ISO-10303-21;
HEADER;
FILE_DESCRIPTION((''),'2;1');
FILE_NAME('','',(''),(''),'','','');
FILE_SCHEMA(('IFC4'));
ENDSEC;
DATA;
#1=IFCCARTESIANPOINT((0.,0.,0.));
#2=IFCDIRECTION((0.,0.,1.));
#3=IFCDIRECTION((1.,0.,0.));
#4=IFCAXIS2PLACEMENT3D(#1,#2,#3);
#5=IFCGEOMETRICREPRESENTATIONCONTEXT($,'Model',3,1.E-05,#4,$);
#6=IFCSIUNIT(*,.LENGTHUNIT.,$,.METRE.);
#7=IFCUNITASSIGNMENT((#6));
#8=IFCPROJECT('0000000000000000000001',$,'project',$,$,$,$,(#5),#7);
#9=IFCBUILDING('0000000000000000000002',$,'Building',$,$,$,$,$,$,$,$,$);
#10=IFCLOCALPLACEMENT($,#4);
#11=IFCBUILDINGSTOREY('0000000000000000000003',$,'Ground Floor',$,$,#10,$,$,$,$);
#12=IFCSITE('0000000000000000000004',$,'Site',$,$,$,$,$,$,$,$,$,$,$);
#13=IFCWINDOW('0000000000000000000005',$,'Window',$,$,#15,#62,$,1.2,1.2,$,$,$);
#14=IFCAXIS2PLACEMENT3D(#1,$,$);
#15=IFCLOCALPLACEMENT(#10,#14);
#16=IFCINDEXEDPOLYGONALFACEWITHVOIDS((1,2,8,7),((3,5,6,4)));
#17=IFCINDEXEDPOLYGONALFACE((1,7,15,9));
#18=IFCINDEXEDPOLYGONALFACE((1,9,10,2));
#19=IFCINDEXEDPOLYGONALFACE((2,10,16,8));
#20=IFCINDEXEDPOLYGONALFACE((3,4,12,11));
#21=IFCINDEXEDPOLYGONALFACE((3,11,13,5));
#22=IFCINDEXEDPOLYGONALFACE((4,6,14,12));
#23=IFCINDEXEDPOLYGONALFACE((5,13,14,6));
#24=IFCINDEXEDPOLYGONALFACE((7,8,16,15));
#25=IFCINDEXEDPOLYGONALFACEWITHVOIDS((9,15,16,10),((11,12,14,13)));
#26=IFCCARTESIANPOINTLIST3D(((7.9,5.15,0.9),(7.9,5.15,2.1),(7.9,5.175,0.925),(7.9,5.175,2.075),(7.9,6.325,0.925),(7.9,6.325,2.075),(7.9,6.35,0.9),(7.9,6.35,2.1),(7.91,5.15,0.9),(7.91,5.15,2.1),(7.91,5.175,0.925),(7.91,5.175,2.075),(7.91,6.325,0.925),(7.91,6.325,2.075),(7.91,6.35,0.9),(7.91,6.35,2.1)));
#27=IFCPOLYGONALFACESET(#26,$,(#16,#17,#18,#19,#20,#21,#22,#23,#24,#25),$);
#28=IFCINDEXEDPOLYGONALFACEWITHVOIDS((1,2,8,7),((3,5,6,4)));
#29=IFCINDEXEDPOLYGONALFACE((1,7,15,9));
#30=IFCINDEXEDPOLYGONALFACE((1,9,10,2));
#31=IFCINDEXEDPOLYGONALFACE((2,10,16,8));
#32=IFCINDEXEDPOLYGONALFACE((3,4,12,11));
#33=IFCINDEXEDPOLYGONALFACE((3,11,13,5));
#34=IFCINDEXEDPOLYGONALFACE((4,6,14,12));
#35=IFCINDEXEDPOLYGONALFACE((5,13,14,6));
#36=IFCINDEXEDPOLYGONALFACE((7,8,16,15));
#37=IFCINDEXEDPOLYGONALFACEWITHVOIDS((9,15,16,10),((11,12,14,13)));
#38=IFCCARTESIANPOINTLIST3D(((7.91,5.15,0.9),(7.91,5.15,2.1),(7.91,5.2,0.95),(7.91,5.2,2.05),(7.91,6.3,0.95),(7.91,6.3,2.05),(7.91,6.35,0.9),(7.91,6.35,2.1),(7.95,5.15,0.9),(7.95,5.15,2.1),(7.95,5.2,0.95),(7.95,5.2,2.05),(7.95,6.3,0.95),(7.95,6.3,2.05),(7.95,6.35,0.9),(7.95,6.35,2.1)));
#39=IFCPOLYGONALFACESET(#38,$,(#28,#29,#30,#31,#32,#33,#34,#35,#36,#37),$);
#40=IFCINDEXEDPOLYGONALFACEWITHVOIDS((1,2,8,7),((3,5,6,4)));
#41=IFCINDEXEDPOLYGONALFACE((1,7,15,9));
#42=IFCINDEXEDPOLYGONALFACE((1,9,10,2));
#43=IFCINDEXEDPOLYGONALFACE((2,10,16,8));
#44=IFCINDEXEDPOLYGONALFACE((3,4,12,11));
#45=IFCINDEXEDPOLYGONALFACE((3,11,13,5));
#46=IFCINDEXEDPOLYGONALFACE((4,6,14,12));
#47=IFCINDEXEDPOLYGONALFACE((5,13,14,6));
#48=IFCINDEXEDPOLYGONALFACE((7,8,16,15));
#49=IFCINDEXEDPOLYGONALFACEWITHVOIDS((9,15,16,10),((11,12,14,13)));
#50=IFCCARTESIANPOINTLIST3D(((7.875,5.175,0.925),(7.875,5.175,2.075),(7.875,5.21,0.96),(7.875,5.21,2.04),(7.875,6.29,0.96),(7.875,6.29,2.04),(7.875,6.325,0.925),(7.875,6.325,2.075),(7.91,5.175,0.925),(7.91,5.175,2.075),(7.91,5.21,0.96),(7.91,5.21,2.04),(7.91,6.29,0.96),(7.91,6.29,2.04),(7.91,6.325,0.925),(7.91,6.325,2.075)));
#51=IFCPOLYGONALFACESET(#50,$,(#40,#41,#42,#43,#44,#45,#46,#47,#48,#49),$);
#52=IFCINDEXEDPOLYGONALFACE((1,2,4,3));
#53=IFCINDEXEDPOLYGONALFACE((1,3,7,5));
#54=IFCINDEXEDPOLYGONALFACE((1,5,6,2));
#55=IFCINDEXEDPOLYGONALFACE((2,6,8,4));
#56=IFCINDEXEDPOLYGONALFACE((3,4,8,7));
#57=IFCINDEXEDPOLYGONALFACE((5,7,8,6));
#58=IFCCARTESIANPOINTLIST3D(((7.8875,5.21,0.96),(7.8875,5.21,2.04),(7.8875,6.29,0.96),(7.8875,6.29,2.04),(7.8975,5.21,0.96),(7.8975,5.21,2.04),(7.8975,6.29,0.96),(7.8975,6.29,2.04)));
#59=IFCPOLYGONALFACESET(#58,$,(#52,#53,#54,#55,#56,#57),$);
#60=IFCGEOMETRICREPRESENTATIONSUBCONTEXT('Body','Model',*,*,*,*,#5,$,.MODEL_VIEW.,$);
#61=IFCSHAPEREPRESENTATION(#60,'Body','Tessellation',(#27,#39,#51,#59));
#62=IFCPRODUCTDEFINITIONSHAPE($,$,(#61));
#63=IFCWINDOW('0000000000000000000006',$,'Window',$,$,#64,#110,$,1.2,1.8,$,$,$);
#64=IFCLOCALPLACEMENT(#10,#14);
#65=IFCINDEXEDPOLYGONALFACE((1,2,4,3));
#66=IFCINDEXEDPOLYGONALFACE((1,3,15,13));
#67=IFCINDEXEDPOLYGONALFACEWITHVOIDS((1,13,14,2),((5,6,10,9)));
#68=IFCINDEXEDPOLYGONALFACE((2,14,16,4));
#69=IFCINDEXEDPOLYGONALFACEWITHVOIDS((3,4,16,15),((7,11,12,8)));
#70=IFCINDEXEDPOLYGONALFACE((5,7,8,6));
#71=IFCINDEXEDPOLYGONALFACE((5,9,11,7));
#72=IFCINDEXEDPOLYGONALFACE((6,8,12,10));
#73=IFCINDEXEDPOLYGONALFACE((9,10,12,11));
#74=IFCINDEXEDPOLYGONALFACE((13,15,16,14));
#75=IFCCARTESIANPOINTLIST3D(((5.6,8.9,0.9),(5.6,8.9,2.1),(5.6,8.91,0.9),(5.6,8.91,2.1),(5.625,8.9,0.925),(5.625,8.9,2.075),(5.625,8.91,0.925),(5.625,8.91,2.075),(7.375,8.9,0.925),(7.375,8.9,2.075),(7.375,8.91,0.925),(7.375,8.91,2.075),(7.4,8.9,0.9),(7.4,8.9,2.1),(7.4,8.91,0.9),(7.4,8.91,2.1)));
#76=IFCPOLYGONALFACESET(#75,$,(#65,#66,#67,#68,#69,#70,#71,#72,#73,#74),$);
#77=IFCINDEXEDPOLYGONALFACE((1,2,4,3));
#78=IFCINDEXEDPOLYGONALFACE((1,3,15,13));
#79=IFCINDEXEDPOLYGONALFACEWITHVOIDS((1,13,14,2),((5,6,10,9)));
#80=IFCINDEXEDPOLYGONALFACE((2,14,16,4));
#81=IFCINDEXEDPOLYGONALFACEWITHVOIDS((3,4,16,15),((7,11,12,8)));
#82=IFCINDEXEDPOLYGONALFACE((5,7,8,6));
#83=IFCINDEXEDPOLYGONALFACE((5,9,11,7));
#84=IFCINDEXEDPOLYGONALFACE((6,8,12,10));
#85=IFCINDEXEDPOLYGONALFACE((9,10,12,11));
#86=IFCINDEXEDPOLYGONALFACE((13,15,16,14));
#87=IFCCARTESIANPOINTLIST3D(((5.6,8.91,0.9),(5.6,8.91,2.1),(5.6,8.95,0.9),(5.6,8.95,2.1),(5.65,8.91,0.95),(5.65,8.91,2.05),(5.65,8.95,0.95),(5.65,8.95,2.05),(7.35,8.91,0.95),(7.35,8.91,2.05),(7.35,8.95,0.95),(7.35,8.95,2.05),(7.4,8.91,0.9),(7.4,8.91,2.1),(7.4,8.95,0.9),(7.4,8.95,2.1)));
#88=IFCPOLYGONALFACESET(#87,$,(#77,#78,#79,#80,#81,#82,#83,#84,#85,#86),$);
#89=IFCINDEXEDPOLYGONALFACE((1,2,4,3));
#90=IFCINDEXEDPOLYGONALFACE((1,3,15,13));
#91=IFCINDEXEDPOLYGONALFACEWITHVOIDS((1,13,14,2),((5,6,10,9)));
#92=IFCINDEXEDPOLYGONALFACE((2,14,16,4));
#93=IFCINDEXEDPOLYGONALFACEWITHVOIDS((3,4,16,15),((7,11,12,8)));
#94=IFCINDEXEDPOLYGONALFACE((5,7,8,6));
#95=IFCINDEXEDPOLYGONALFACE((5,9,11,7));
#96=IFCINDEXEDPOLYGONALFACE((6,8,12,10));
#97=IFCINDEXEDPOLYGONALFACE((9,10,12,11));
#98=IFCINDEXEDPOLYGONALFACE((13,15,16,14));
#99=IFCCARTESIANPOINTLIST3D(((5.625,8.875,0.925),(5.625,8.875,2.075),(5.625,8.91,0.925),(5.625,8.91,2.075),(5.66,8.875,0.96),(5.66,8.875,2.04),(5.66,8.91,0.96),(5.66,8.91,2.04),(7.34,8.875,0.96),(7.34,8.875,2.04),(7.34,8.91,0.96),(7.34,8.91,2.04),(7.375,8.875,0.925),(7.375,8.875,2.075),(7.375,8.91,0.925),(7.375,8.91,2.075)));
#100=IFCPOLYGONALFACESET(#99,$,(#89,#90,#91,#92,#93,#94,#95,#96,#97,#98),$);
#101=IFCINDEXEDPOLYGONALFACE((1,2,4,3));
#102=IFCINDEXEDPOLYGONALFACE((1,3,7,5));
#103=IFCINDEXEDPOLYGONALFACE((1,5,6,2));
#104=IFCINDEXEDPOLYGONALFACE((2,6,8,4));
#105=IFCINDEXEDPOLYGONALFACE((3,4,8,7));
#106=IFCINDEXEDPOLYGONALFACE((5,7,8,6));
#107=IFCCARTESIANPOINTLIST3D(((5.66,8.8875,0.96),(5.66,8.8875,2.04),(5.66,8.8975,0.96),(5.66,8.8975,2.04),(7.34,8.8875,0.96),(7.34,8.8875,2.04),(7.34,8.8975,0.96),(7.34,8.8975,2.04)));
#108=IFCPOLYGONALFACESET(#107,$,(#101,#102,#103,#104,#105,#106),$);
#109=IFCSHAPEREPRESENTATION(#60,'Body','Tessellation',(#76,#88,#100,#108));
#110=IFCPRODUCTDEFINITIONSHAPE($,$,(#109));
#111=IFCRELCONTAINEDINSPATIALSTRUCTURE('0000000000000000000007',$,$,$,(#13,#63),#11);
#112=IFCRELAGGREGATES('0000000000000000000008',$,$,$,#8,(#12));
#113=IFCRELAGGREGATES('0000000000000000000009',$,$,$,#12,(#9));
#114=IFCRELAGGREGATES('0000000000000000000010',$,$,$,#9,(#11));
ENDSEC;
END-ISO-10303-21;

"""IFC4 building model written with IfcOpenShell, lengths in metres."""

from ifc_helpers import new_model, si_unit, frame, origin_with_axes, place, context, subcontext, project, spatial, line, indexed_curve, outline, extrude, element, save


model = new_model("IFC4")

# Units and contexts
model_context = context("Model", 3, precision=1e-05, world=origin_with_axes())
body_context = subcontext(model_context, "Body", "Model", "MODEL_VIEW")
ifc_project = project(units=[si_unit("LENGTHUNIT", "METRE")], contexts=[model_context])

# Site, building, storey
site = spatial("IfcSite", under=ifc_project, Name="Site")
building = spatial("IfcBuilding", under=site, Name="Building")
storey_placement = place(None, origin_with_axes())
storey = spatial("IfcBuildingStorey", under=building, at=storey_placement, Name="Ground Floor")

# Windows
window_1_placement = place(storey_placement, frame((8.0, 5.15, 0.9), z_axis=(0.0, 0.0, 1.0), x_axis=(0.0, 1.0, 0.0)))
element("IfcWindow", 1, at=window_1_placement, inside=storey, Name="Window", OverallHeight=1.2, OverallWidth=1.2, context=body_context, shape_type="SweptSolid", body=[
    extrude(outline(indexed_curve([(0.0, 0.0), (1.2, 0.0), (1.2, 1.2), (0.0, 1.2)], segments=[line(1, 2, 3, 4, 1)]), holes=[indexed_curve([(0.025, 0.025), (1.175, 0.025), (1.175, 1.175), (0.025, 1.175)], segments=[line(1, 2, 3, 4, 1)])]), frame((0.0, 0.09, 0.0), z_axis=(0.0, -1.0, 0.0), x_axis=(1.0, 0.0, 0.0)), (0.0, 0.0, -1.0), 0.01),
    extrude(outline(indexed_curve([(0.0, 0.0), (1.2, 0.0), (1.2, 1.2), (0.0, 1.2)], segments=[line(1, 2, 3, 4, 1)]), holes=[indexed_curve([(0.05, 0.05), (1.15, 0.05), (1.15, 1.15), (0.05, 1.15)], segments=[line(1, 2, 3, 4, 1)])]), frame((0.0, 0.05, 0.0), z_axis=(0.0, -1.0, 0.0), x_axis=(1.0, 0.0, 0.0)), (0.0, 0.0, -1.0), 0.04),
    extrude(outline(indexed_curve([(0.0, 0.0), (1.15, 0.0), (1.15, 1.15), (0.0, 1.15)], segments=[line(1, 2, 3, 4, 1)]), holes=[indexed_curve([(0.035, 0.035), (1.115, 0.035), (1.115, 1.115), (0.035, 1.115)], segments=[line(1, 2, 3, 4, 1)])]), frame((0.025, 0.09, 0.025), z_axis=(0.0, -1.0, 0.0), x_axis=(1.0, 0.0, 0.0)), (0.0, 0.0, -1.0), 0.035),
    extrude(outline(indexed_curve([(0.035, 0.035), (1.115, 0.035), (1.115, 1.115), (0.035, 1.115)], segments=[line(1, 2, 3, 4, 1)])), frame((0.025, 0.1025, 0.025), z_axis=(0.0, -1.0, 0.0), x_axis=(1.0, 0.0, 0.0)), (0.0, 0.0, -1.0), 0.01),
])
window_2_placement = place(storey_placement, frame((7.4, 9.0, 0.9), z_axis=(0.0, 0.0, 1.0), x_axis=(-1.0, 0.0, 0.0)))
element("IfcWindow", 2, at=window_2_placement, inside=storey, Name="Window", OverallHeight=1.2, OverallWidth=1.8, context=body_context, shape_type="SweptSolid", body=[
    extrude(outline(indexed_curve([(0.0, 0.0), (1.8, 0.0), (1.8, 1.2), (0.0, 1.2)], segments=[line(1, 2, 3, 4, 1)]), holes=[indexed_curve([(0.025, 0.025), (1.775, 0.025), (1.775, 1.175), (0.025, 1.175)], segments=[line(1, 2, 3, 4, 1)])]), frame((0.0, 0.09, 0.0), z_axis=(0.0, -1.0, 0.0), x_axis=(1.0, 0.0, 0.0)), (0.0, 0.0, -1.0), 0.01),
    extrude(outline(indexed_curve([(0.0, 0.0), (1.8, 0.0), (1.8, 1.2), (0.0, 1.2)], segments=[line(1, 2, 3, 4, 1)]), holes=[indexed_curve([(0.05, 0.05), (1.75, 0.05), (1.75, 1.15), (0.05, 1.15)], segments=[line(1, 2, 3, 4, 1)])]), frame((0.0, 0.05, 0.0), z_axis=(0.0, -1.0, 0.0), x_axis=(1.0, 0.0, 0.0)), (0.0, 0.0, -1.0), 0.04),
    extrude(outline(indexed_curve([(0.0, 0.0), (1.75, 0.0), (1.75, 1.15), (0.0, 1.15)], segments=[line(1, 2, 3, 4, 1)]), holes=[indexed_curve([(0.035, 0.035), (1.715, 0.035), (1.715, 1.115), (0.035, 1.115)], segments=[line(1, 2, 3, 4, 1)])]), frame((0.025, 0.09, 0.025), z_axis=(0.0, -1.0, 0.0), x_axis=(1.0, 0.0, 0.0)), (0.0, 0.0, -1.0), 0.035),
    extrude(outline(indexed_curve([(0.035, 0.035), (1.715, 0.035), (1.715, 1.115), (0.035, 1.115)], segments=[line(1, 2, 3, 4, 1)])), frame((0.025, 0.1025, 0.025), z_axis=(0.0, -1.0, 0.0), x_axis=(1.0, 0.0, 0.0)), (0.0, 0.0, -1.0), 0.01),
])

save(model, "model.ifc")
